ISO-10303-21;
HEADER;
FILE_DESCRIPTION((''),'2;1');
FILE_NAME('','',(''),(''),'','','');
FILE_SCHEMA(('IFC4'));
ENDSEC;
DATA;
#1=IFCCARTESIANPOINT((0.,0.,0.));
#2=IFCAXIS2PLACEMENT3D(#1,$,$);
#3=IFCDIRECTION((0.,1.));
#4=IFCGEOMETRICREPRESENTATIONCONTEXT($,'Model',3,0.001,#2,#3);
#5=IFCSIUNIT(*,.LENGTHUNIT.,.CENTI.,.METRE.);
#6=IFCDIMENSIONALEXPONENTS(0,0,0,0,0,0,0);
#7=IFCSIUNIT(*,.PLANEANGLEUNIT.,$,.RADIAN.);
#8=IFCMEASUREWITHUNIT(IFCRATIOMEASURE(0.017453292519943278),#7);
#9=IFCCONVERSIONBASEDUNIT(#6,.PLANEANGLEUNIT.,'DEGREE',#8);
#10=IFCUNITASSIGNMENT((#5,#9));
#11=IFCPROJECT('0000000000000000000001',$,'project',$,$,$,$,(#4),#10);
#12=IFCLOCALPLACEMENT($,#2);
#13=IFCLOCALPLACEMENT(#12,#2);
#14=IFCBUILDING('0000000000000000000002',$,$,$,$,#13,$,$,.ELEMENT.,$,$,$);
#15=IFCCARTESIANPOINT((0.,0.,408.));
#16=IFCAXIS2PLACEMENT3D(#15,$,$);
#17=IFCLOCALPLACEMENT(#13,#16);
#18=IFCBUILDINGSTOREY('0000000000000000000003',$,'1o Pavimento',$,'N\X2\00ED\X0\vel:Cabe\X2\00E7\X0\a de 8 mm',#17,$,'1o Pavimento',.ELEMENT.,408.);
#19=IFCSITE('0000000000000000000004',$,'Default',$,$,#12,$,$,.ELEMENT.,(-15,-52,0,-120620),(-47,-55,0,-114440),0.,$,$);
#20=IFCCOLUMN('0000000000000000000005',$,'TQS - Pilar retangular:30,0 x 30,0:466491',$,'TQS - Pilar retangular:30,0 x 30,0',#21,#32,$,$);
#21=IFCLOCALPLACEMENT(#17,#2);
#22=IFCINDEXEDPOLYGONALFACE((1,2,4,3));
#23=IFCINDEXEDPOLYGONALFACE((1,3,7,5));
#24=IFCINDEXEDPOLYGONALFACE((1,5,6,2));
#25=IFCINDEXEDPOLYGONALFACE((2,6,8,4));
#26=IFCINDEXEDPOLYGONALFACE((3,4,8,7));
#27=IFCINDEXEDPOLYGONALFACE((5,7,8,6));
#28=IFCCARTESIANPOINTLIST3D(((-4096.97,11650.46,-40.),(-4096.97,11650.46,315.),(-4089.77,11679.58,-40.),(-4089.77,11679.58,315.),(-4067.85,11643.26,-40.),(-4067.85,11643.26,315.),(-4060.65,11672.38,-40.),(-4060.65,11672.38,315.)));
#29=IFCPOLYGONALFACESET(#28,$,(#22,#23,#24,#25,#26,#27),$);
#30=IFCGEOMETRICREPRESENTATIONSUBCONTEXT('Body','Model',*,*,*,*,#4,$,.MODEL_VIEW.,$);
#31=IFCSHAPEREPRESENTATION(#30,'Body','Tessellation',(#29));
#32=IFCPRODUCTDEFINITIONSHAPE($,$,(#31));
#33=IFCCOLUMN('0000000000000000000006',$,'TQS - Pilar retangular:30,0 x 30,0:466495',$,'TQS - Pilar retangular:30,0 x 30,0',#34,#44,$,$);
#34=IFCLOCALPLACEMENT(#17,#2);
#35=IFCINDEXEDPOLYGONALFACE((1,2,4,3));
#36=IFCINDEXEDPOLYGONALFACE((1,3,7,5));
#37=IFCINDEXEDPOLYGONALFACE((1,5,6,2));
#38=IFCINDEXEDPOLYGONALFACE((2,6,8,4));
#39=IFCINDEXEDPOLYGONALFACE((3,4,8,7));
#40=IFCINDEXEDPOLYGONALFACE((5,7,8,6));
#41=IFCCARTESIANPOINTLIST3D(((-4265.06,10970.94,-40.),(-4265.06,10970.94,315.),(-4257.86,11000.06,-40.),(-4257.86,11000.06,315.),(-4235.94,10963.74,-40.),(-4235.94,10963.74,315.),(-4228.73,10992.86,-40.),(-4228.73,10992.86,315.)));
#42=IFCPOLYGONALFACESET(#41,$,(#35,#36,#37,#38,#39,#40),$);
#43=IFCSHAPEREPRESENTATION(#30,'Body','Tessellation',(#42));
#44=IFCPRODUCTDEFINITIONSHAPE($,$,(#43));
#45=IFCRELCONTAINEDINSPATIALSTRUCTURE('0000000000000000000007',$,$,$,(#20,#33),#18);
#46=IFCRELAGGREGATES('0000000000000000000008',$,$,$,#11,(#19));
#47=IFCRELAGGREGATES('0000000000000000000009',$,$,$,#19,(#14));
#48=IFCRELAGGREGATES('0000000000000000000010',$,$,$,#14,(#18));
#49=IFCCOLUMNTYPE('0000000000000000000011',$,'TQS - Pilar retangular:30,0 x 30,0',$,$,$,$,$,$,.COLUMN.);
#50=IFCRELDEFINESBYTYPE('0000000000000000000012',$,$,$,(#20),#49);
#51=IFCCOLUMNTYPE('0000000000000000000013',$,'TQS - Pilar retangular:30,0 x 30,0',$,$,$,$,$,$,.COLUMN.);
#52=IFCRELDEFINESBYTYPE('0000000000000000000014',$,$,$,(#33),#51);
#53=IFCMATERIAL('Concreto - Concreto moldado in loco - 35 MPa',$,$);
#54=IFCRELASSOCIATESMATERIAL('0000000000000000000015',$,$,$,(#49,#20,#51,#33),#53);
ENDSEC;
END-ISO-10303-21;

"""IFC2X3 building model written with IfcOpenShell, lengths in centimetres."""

from ifc_helpers import new_model, entity, si_unit, converted_unit, direction, frame, origin, origin_2d_with_axis, place, context, subcontext, project, spatial, rectangle, extrude, source, transform, mapped, material, type_object, type_shapes, element, save


model = new_model("IFC2X3")

# Units and contexts
model_context = context("Model", 3, precision=0.001, world=origin(), true_north=direction((0.0, 1.0)))
body_context = subcontext(model_context, "Body", "Model", "MODEL_VIEW")
ifc_project = project(units=[si_unit("LENGTHUNIT", "METRE", prefix="CENTI"), converted_unit("PLANEANGLEUNIT", "DEGREE", entity("IfcRatioMeasure", 0.017453292519943278), si_unit("PLANEANGLEUNIT", "RADIAN"), dimensions=[0, 0, 0, 0, 0, 0, 0])], contexts=[model_context])

# Site, building, storey
site_placement = place(None, origin())
site = spatial("IfcSite", under=ifc_project, at=site_placement, Name="Default", CompositionType="ELEMENT", RefLatitude=(-15, -52, 0, -120620), RefLongitude=(-47, -55, 0, -114440), RefElevation=0.0)
building_placement = place(site_placement, origin())
building = spatial("IfcBuilding", under=site, at=building_placement, CompositionType="ELEMENT")
storey_placement = place(building_placement, frame((0.0, 0.0, 408.0)))
storey = spatial("IfcBuildingStorey", under=building, at=storey_placement, Name="1o Pavimento", ObjectType="Nível:Cabeça de 8 mm", LongName="1o Pavimento", CompositionType="ELEMENT", Elevation=408.0)

# Columns
ifc_material = material(Name="Concreto - Concreto moldado in loco - 35 MPa")
column_type_1 = type_object("IfcColumnType", Name="TQS - Pilar retangular:30,0 x 30,0", PredefinedType="COLUMN", material=ifc_material)
shared_shape_1 = source(origin(), body_context, "Body", "SweptSolid", [
    extrude(rectangle(XDim=30.0, YDim=30.0, at=origin_2d_with_axis()), frame((-4078.81, 11661.42, 368.0), z_axis=(0.0, 0.0, 1.0), x_axis=(-0.970743, 0.240122, 0.0)), (0.0, 0.0, 1.0), 355.0),
])
type_shapes(column_type_1, [shared_shape_1])
column_1_placement = place(storey_placement, frame((0.0, 0.0, -408.0)))
element("IfcColumn", 1, at=column_1_placement, inside=storey, type_object=column_type_1, material=ifc_material, Name="TQS - Pilar retangular:30,0 x 30,0:466491", ObjectType="TQS - Pilar retangular:30,0 x 30,0", context=body_context, shape_type="MappedRepresentation", body=[
    mapped(shared_shape_1, transform((0.0, 0.0, 0.0), scale=1.0)),
])
column_type_2 = type_object("IfcColumnType", Name="TQS - Pilar retangular:30,0 x 30,0", PredefinedType="COLUMN", material=ifc_material)
shared_shape_2 = source(origin(), body_context, "Body", "SweptSolid", [
    extrude(rectangle(XDim=30.0, YDim=30.0, at=origin_2d_with_axis()), frame((-4246.9, 10981.9, 368.0), z_axis=(0.0, 0.0, 1.0), x_axis=(-0.970743, 0.240122, 0.0)), (0.0, 0.0, 1.0), 355.0),
])
type_shapes(column_type_2, [shared_shape_2])
column_2_placement = place(storey_placement, frame((0.0, 0.0, -408.0)))
element("IfcColumn", 2, at=column_2_placement, inside=storey, type_object=column_type_2, material=ifc_material, Name="TQS - Pilar retangular:30,0 x 30,0:466495", ObjectType="TQS - Pilar retangular:30,0 x 30,0", context=body_context, shape_type="MappedRepresentation", body=[
    mapped(shared_shape_2, transform((0.0, 0.0, 0.0), scale=1.0)),
])

save(model, "model.ifc")
